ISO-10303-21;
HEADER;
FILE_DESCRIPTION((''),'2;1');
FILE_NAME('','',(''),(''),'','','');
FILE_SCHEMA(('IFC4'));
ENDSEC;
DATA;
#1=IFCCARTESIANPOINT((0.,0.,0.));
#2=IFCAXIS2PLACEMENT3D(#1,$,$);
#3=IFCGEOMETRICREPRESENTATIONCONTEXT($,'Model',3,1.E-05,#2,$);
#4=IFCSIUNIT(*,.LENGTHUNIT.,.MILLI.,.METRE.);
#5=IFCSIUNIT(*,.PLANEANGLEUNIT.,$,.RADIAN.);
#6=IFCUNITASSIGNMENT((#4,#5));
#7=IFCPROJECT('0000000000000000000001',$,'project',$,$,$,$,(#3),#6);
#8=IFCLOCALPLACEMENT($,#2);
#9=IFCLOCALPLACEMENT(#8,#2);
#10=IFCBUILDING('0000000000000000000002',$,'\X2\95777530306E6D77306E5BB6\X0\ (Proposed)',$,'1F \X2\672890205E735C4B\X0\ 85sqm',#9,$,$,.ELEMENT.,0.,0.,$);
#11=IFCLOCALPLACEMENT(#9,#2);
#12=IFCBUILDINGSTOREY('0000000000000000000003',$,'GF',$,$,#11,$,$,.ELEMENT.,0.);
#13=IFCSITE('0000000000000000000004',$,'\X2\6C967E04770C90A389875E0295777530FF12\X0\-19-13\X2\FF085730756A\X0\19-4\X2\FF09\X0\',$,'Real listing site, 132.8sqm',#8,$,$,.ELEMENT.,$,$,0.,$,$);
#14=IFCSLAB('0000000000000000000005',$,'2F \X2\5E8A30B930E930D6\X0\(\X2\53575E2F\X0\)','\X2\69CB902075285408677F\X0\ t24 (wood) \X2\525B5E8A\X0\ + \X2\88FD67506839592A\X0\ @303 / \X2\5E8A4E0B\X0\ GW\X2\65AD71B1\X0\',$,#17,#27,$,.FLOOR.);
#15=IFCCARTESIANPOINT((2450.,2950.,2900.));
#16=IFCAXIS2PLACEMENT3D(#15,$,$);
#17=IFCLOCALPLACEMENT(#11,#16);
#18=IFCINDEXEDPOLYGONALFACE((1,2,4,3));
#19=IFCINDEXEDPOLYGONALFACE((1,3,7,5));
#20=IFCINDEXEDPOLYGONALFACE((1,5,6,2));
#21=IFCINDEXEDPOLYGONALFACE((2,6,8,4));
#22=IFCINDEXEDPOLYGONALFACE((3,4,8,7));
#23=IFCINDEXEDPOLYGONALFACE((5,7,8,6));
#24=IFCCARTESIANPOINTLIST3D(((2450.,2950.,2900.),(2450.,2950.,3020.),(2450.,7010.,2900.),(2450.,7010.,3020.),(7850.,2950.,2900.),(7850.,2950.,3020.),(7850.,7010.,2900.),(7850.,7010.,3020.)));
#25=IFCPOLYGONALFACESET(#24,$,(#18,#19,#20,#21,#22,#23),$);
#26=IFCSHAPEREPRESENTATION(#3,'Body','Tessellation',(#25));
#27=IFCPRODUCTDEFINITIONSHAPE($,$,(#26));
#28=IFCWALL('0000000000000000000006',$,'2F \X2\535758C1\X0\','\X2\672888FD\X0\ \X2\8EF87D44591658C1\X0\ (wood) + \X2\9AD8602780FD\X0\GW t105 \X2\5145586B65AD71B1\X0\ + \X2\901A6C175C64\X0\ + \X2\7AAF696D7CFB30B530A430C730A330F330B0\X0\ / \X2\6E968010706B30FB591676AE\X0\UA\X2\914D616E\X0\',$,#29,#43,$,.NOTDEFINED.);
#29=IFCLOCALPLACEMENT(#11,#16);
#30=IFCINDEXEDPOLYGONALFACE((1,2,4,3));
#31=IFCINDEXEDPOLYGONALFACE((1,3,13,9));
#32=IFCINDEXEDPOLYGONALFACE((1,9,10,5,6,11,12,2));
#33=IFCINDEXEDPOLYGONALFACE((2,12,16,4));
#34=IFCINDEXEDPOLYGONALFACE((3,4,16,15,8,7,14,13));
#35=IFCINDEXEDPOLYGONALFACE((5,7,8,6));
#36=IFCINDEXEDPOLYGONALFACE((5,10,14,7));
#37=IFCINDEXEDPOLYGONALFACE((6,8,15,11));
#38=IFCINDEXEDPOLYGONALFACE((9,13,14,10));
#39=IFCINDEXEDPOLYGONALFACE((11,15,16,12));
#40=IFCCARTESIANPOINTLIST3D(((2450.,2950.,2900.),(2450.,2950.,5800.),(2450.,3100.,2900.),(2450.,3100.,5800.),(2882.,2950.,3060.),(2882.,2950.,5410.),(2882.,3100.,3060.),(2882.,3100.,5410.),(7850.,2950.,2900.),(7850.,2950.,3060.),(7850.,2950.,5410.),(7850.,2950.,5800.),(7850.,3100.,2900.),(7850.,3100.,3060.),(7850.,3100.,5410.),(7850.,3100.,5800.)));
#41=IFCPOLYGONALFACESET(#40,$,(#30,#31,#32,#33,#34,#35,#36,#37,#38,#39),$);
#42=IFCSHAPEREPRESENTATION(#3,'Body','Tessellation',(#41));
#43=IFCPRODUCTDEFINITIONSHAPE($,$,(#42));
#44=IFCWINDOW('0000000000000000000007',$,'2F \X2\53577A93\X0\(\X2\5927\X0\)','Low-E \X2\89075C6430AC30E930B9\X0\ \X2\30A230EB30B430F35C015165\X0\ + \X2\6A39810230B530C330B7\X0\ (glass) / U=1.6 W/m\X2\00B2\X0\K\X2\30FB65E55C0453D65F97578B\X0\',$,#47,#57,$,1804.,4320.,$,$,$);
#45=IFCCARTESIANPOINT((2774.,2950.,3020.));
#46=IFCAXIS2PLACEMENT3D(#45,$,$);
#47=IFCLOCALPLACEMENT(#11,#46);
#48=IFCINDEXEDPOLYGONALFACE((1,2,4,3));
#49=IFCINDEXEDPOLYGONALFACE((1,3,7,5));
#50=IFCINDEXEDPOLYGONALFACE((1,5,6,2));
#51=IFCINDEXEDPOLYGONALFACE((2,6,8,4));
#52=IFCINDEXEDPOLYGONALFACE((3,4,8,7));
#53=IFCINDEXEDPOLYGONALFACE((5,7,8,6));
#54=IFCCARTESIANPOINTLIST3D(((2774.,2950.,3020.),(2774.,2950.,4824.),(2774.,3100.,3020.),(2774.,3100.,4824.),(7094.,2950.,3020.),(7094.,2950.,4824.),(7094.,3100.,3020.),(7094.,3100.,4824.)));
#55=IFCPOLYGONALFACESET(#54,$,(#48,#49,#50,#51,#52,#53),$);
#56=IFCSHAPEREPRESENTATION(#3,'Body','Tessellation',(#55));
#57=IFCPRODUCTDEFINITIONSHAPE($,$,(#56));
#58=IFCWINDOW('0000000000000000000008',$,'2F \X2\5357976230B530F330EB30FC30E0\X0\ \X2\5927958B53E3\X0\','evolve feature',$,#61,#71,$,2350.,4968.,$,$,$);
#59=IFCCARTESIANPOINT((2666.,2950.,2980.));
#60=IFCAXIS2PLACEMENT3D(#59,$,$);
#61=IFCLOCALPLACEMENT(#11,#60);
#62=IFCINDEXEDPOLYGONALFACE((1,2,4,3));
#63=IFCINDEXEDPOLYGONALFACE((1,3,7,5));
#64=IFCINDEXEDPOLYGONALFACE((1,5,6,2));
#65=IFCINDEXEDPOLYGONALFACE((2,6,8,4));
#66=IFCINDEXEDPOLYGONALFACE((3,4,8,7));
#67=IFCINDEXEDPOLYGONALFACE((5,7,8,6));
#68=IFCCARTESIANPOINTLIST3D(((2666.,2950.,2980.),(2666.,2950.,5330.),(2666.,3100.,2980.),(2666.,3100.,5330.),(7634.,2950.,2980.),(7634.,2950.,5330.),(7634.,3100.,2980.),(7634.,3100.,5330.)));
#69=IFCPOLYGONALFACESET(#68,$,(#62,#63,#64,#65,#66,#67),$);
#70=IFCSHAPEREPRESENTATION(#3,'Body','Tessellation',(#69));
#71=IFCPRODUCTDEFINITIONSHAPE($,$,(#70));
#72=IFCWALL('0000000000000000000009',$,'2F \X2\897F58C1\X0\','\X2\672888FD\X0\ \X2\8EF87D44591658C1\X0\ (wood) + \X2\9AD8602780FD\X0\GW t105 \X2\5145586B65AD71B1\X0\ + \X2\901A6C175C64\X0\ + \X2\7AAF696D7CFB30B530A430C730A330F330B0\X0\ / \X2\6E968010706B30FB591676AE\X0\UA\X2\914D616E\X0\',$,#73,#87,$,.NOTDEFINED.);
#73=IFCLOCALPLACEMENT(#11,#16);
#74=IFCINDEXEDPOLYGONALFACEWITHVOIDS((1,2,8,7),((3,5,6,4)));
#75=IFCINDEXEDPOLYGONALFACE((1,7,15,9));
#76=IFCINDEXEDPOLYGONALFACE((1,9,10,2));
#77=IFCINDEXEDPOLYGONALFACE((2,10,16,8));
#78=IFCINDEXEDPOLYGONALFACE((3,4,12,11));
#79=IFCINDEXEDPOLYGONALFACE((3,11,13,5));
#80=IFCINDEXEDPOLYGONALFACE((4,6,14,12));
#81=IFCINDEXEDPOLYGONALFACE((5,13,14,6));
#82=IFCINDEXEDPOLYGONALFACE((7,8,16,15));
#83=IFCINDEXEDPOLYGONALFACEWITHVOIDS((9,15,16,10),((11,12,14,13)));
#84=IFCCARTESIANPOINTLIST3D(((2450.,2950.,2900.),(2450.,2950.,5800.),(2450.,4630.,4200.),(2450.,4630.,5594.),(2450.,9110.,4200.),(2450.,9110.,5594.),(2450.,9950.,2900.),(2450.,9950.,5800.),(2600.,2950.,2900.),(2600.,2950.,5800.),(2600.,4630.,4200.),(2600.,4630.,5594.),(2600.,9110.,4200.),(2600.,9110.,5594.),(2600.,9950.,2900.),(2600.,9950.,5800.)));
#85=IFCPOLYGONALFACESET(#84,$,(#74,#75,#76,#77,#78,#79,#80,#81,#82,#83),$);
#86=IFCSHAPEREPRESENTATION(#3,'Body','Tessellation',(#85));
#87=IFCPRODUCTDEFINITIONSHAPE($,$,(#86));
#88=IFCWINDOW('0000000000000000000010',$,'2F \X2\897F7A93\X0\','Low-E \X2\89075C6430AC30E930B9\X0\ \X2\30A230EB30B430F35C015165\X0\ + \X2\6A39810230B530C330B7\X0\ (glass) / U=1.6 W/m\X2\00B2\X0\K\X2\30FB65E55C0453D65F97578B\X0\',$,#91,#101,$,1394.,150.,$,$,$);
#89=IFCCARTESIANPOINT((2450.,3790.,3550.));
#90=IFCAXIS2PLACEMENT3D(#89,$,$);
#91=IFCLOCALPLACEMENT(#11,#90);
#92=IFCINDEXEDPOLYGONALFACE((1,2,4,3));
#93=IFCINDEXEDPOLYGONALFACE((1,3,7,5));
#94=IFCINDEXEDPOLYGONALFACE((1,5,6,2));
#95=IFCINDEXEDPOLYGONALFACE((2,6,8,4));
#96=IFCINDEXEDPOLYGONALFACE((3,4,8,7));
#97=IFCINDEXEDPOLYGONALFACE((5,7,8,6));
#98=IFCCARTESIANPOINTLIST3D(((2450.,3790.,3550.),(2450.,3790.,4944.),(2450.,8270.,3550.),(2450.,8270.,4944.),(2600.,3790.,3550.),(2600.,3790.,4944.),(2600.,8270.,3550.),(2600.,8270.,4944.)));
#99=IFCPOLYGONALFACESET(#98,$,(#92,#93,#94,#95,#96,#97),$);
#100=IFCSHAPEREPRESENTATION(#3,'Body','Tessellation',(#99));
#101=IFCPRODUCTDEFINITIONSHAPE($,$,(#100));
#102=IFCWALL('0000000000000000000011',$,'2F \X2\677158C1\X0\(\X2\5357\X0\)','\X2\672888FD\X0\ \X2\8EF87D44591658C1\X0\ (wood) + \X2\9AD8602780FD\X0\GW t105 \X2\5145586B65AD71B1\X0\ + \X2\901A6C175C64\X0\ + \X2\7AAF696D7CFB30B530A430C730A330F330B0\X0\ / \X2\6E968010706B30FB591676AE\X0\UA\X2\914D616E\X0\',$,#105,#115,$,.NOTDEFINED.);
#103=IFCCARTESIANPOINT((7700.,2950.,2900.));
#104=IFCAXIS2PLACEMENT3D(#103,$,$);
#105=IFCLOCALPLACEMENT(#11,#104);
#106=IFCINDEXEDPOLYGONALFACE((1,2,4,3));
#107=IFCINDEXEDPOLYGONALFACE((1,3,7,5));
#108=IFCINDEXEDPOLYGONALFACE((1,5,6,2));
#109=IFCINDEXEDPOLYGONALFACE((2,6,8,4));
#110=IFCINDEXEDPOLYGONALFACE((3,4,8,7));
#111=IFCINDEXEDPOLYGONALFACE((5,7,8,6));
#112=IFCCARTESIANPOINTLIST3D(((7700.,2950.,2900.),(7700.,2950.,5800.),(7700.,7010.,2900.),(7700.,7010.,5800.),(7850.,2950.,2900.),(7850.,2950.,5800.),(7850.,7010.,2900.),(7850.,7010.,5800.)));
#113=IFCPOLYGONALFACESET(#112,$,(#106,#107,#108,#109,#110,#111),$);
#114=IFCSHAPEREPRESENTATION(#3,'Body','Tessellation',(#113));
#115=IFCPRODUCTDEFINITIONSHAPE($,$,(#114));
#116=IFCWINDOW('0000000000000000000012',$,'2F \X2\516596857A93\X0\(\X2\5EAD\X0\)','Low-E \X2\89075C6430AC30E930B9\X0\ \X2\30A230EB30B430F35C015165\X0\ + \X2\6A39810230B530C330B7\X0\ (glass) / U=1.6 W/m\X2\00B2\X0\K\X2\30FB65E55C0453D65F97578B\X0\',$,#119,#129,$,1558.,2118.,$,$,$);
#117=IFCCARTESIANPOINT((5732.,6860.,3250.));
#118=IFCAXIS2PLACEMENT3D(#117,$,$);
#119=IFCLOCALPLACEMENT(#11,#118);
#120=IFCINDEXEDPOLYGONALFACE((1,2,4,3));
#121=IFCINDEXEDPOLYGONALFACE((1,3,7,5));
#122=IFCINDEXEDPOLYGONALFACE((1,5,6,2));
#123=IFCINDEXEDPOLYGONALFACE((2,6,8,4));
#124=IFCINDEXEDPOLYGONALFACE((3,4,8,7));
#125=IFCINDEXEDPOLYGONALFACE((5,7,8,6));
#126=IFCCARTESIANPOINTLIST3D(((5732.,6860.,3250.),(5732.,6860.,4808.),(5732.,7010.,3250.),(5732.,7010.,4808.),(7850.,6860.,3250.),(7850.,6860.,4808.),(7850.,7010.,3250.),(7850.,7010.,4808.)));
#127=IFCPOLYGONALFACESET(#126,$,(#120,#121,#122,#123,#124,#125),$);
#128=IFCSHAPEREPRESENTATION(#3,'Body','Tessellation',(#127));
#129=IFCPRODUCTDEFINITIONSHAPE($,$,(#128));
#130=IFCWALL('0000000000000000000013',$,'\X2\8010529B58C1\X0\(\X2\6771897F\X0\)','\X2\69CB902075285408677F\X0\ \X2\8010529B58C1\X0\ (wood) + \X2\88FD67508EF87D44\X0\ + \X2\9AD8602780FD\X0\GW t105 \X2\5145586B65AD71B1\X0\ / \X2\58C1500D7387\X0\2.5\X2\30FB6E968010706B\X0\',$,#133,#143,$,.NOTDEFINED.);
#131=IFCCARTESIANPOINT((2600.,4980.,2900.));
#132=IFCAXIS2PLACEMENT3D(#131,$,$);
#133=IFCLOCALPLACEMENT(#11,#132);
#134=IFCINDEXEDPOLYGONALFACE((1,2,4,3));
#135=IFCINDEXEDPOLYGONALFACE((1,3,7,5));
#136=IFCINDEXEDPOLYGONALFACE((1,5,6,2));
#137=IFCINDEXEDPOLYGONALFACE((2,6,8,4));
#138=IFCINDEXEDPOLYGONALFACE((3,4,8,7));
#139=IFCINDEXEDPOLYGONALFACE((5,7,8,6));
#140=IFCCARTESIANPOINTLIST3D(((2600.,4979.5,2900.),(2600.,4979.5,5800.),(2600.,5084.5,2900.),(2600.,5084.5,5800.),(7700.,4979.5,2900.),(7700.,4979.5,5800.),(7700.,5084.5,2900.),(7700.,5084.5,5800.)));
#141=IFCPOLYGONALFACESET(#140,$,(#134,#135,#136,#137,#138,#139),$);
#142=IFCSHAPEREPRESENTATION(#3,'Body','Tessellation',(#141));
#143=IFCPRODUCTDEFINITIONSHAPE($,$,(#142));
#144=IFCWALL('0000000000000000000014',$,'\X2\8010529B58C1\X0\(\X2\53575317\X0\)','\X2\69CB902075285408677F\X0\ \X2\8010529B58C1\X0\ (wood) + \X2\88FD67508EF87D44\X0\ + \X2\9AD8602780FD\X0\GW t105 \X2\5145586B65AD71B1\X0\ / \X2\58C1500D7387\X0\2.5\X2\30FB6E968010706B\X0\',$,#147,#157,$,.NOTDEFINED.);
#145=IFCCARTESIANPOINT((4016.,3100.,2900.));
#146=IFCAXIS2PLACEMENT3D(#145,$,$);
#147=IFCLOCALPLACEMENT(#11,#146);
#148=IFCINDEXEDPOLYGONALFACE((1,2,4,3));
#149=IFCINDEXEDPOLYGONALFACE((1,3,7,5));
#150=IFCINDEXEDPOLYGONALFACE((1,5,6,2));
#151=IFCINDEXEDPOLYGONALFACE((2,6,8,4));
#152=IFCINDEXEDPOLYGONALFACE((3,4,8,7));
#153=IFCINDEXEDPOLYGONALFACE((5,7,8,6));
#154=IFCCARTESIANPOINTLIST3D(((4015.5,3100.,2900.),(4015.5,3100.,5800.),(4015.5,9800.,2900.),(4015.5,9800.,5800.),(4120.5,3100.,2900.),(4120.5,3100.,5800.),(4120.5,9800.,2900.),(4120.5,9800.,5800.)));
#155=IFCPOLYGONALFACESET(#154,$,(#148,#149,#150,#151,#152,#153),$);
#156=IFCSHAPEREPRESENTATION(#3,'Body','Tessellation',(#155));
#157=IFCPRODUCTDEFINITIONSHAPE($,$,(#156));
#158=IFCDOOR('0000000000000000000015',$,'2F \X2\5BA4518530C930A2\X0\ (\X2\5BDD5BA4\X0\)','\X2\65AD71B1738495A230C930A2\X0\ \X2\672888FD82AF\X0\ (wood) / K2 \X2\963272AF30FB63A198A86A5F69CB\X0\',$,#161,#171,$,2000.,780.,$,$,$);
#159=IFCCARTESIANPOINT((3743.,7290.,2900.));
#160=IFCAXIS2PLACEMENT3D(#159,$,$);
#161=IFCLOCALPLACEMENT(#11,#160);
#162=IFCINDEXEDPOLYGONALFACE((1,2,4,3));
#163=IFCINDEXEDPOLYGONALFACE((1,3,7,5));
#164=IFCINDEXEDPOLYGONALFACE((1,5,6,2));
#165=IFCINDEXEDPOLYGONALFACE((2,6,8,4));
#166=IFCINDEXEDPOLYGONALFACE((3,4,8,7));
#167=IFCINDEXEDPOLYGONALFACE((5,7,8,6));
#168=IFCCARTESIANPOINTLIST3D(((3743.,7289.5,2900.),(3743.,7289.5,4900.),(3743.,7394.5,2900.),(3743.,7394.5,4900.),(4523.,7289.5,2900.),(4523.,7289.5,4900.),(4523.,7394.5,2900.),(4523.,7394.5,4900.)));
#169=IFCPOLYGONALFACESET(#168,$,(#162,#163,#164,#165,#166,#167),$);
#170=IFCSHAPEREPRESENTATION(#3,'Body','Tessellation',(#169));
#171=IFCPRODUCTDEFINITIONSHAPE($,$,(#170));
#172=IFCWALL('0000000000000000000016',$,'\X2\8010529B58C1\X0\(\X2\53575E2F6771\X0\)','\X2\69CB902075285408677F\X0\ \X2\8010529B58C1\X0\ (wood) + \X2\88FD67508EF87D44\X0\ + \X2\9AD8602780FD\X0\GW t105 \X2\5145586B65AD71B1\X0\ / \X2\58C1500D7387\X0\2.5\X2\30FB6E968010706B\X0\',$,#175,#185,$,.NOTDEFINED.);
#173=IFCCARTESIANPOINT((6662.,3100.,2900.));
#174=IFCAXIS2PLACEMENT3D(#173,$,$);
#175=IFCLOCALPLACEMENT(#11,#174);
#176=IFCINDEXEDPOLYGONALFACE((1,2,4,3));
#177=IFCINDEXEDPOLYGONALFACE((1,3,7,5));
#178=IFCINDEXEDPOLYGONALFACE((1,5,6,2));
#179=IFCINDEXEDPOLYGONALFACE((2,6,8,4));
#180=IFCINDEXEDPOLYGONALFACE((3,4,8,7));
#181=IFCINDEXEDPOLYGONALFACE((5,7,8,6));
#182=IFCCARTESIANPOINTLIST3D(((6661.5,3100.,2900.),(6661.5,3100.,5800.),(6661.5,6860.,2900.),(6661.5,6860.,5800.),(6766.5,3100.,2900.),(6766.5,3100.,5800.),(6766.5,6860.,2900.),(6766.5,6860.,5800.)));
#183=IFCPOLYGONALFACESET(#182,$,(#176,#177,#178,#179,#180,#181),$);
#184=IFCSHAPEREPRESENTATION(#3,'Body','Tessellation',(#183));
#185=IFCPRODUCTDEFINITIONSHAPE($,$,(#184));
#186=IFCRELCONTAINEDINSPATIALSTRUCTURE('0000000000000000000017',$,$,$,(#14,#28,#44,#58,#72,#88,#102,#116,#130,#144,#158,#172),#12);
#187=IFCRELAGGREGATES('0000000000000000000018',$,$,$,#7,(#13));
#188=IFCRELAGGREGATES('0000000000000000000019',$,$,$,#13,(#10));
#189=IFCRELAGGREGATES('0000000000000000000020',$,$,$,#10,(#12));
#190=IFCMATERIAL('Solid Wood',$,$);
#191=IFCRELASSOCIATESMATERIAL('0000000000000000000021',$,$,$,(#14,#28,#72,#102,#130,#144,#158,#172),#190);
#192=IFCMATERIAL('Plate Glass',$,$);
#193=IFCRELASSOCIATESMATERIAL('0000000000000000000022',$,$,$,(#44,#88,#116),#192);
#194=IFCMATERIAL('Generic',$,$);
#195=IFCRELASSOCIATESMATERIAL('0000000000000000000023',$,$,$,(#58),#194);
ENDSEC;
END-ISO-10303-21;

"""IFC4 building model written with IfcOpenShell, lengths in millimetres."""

from ifc_helpers import new_model, si_unit, frame, frame_2d, origin, place, context, project, spatial, rectangle, extrude, material, element, fill, save


model = new_model("IFC4")

# Units and contexts
model_context = context("Model", 3, precision=1e-05, world=origin())
ifc_project = project(units=[si_unit("LENGTHUNIT", "METRE", prefix="MILLI"), si_unit("PLANEANGLEUNIT", "RADIAN")], contexts=[model_context])

# Site, building, storey
site_placement = place(None, origin())
site = spatial("IfcSite", under=ifc_project, at=site_placement, Name="沖縄県那覇市長田２-19-13（地番19-4）", ObjectType="Real listing site, 132.8sqm", CompositionType="ELEMENT", RefElevation=0.0)
building_placement = place(site_placement, origin())
building = spatial("IfcBuilding", under=site, at=building_placement, Name="長田の海の家 (Proposed)", ObjectType="1F 木造平屋 85sqm", CompositionType="ELEMENT", ElevationOfRefHeight=0.0, ElevationOfTerrain=0.0)
storey_placement = place(building_placement, origin())
storey = spatial("IfcBuildingStorey", under=building, at=storey_placement, Name="GF", CompositionType="ELEMENT", Elevation=0.0)

# Slab
ifc_material_1 = material(Name="Solid Wood")
slab_placement = place(storey_placement, frame((2450.0, 2950.0, 2900.0)))
element("IfcSlab", 1, at=slab_placement, inside=storey, material=ifc_material_1, Name="2F 床スラブ(南帯)", Description="構造用合板 t24 (wood) 剛床 + 製材根太 @303 / 床下 GW断熱", PredefinedType="FLOOR", context=model_context, shape_type="SweptSolid", body=[
    extrude(rectangle(XDim=5400.0, YDim=4060.0, at=frame_2d((2700.0, 2030.0))), frame((2450.0, 2950.0, 2900.0)), (0.0, 0.0, 1.0), 120.0),
])

# Wall, openings, windows
wall_1_placement = place(storey_placement, frame((2450.0, 2950.0, 2900.0)))
wall_1 = element("IfcWall", 2, at=wall_1_placement, inside=storey, material=ifc_material_1, Name="2F 南壁", Description="木製 軸組外壁 (wood) + 高性能GW t105 充填断熱 + 通気層 + 窯業系サイディング / 準耐火・外皮UA配慮", PredefinedType="NOTDEFINED", context=model_context, shape_type="SweptSolid", body=[
    extrude(rectangle(XDim=5400.0, YDim=150.0, at=frame_2d((2700.0, 75.0))), frame((2450.0, 2950.0, 2900.0)), (0.0, 0.0, 1.0), 2900.0),
])
opening_1_placement = place(storey_placement, frame((2774.0, 2950.0, 3020.0)))
opening_1 = element("IfcOpeningElement", 3, at=opening_1_placement, cuts=wall_1, PredefinedType="NOTDEFINED", context=model_context, shape_type="SweptSolid", body=[
    extrude(rectangle(XDim=4320.0, YDim=150.0, at=frame_2d((2160.0, 75.0))), frame((2774.0, 2950.0, 3020.0)), (0.0, 0.0, 1.0), 1804.0),
])
opening_2_placement = place(storey_placement, frame((2666.0, 2950.0, 2980.0)))
opening_2 = element("IfcOpeningElement", 4, at=opening_2_placement, cuts=wall_1, PredefinedType="NOTDEFINED", context=model_context, shape_type="SweptSolid", body=[
    extrude(rectangle(XDim=4968.0, YDim=150.0, at=frame_2d((2484.0, 75.0))), frame((2666.0, 2950.0, 2980.0)), (0.0, 0.0, 1.0), 2350.0),
])
ifc_material_2 = material(Name="Plate Glass")
window_1_placement = place(storey_placement, frame((2774.0, 2950.0, 3020.0)))
window_1 = element("IfcWindow", 5, at=window_1_placement, inside=storey, material=ifc_material_2, Name="2F 南窓(大)", Description="Low-E 複層ガラス アルゴン封入 + 樹脂サッシ (glass) / U=1.6 W/m²K・日射取得型", OverallHeight=1804.0, OverallWidth=4320.0, context=model_context, shape_type="SweptSolid", body=[
    extrude(rectangle(XDim=4320.0, YDim=150.0, at=frame_2d((2160.0, 75.0))), frame((2774.0, 2950.0, 3020.0)), (0.0, 0.0, 1.0), 1804.0),
])
fill(opening_1, window_1)
ifc_material_3 = material(Name="Generic")
window_2_placement = place(storey_placement, frame((2666.0, 2950.0, 2980.0)))
window_2 = element("IfcWindow", 6, at=window_2_placement, inside=storey, material=ifc_material_3, Name="2F 南面サンルーム 大開口", Description="evolve feature", OverallHeight=2350.0, OverallWidth=4968.0, context=model_context, shape_type="SweptSolid", body=[
    extrude(rectangle(XDim=4968.0, YDim=150.0, at=frame_2d((2484.0, 75.0))), frame((2666.0, 2950.0, 2980.0)), (0.0, 0.0, 1.0), 2350.0),
])
fill(opening_2, window_2)

# Walls, openings, windows
wall_2_placement = place(storey_placement, frame((2450.0, 2950.0, 2900.0)))
wall_2 = element("IfcWall", 7, at=wall_2_placement, inside=storey, material=ifc_material_1, Name="2F 西壁", Description="木製 軸組外壁 (wood) + 高性能GW t105 充填断熱 + 通気層 + 窯業系サイディング / 準耐火・外皮UA配慮", PredefinedType="NOTDEFINED", context=model_context, shape_type="SweptSolid", body=[
    extrude(rectangle(XDim=150.0, YDim=7000.0, at=frame_2d((75.0, 3500.0))), frame((2450.0, 2950.0, 2900.0)), (0.0, 0.0, 1.0), 2900.0),
])
opening_3_placement = place(storey_placement, frame((2450.0, 3790.0, 3550.0)))
opening_3 = element("IfcOpeningElement", 8, at=opening_3_placement, cuts=wall_2, PredefinedType="NOTDEFINED", context=model_context, shape_type="SweptSolid", body=[
    extrude(rectangle(XDim=150.0, YDim=4480.0, at=frame_2d((75.0, 2240.0))), frame((2450.0, 3790.0, 3550.0)), (0.0, 0.0, 1.0), 1394.0),
])
window_3_placement = place(storey_placement, frame((2450.0, 3790.0, 3550.0)))
window_3 = element("IfcWindow", 9, at=window_3_placement, inside=storey, material=ifc_material_2, Name="2F 西窓", Description="Low-E 複層ガラス アルゴン封入 + 樹脂サッシ (glass) / U=1.6 W/m²K・日射取得型", OverallHeight=1394.0, OverallWidth=150.0, context=model_context, shape_type="SweptSolid", body=[
    extrude(rectangle(XDim=150.0, YDim=4480.0, at=frame_2d((75.0, 2240.0))), frame((2450.0, 3790.0, 3550.0)), (0.0, 0.0, 1.0), 1394.0),
])
fill(opening_3, window_3)
wall_3_placement = place(storey_placement, frame((7700.0, 2950.0, 2900.0)))
wall_3 = element("IfcWall", 10, at=wall_3_placement, inside=storey, material=ifc_material_1, Name="2F 東壁(南)", Description="木製 軸組外壁 (wood) + 高性能GW t105 充填断熱 + 通気層 + 窯業系サイディング / 準耐火・外皮UA配慮", PredefinedType="NOTDEFINED", context=model_context, shape_type="SweptSolid", body=[
    extrude(rectangle(XDim=150.0, YDim=4060.0, at=frame_2d((75.0, 2030.0))), frame((7700.0, 2950.0, 2900.0)), (0.0, 0.0, 1.0), 2900.0),
])
opening_4_placement = place(storey_placement, frame((5732.0, 6860.0, 3250.0)))
opening_4 = element("IfcOpeningElement", 11, at=opening_4_placement, cuts=wall_3, PredefinedType="NOTDEFINED", context=model_context, shape_type="SweptSolid", body=[
    extrude(rectangle(XDim=2118.0, YDim=150.0, at=frame_2d((1059.0, 75.0))), frame((5732.0, 6860.0, 3250.0)), (0.0, 0.0, 1.0), 1558.0),
])
window_4_placement = place(storey_placement, frame((5732.0, 6860.0, 3250.0)))
window_4 = element("IfcWindow", 12, at=window_4_placement, inside=storey, material=ifc_material_2, Name="2F 入隅窓(庭)", Description="Low-E 複層ガラス アルゴン封入 + 樹脂サッシ (glass) / U=1.6 W/m²K・日射取得型", OverallHeight=1558.0, OverallWidth=2118.0, context=model_context, shape_type="SweptSolid", body=[
    extrude(rectangle(XDim=2118.0, YDim=150.0, at=frame_2d((1059.0, 75.0))), frame((5732.0, 6860.0, 3250.0)), (0.0, 0.0, 1.0), 1558.0),
])
fill(opening_4, window_4)

# Wall
wall_4_placement = place(storey_placement, frame((2600.0, 4980.0, 2900.0)))
element("IfcWall", 13, at=wall_4_placement, inside=storey, material=ifc_material_1, Name="耐力壁(東西)", Description="構造用合板 耐力壁 (wood) + 製材軸組 + 高性能GW t105 充填断熱 / 壁倍率2.5・準耐火", PredefinedType="NOTDEFINED", context=model_context, shape_type="SweptSolid", body=[
    extrude(rectangle(XDim=5100.0, YDim=105.0, at=frame_2d((2550.0, 52.0))), frame((2600.0, 4980.0, 2900.0)), (0.0, 0.0, 1.0), 2900.0),
])

# Wall, opening, door
wall_5_placement = place(storey_placement, frame((4016.0, 3100.0, 2900.0)))
wall_5 = element("IfcWall", 14, at=wall_5_placement, inside=storey, material=ifc_material_1, Name="耐力壁(南北)", Description="構造用合板 耐力壁 (wood) + 製材軸組 + 高性能GW t105 充填断熱 / 壁倍率2.5・準耐火", PredefinedType="NOTDEFINED", context=model_context, shape_type="SweptSolid", body=[
    extrude(rectangle(XDim=105.0, YDim=6700.0, at=frame_2d((52.0, 3350.0))), frame((4016.0, 3100.0, 2900.0)), (0.0, 0.0, 1.0), 2900.0),
])
opening_5_placement = place(storey_placement, frame((3743.0, 7290.0, 2900.0)))
opening_5 = element("IfcOpeningElement", 15, at=opening_5_placement, cuts=wall_5, PredefinedType="NOTDEFINED", context=model_context, shape_type="SweptSolid", body=[
    extrude(rectangle(XDim=780.0, YDim=105.0, at=frame_2d((390.0, 52.0))), frame((3743.0, 7290.0, 2900.0)), (0.0, 0.0, 1.0), 2000.0),
])
door_placement = place(storey_placement, frame((3743.0, 7290.0, 2900.0)))
door = element("IfcDoor", 16, at=door_placement, inside=storey, material=ifc_material_1, Name="2F 室内ドア (寝室)", Description="断熱玄関ドア 木製芯 (wood) / K2 防犯・採風機構", OverallHeight=2000.0, OverallWidth=780.0, context=model_context, shape_type="SweptSolid", body=[
    extrude(rectangle(XDim=780.0, YDim=105.0, at=frame_2d((390.0, 52.0))), frame((3743.0, 7290.0, 2900.0)), (0.0, 0.0, 1.0), 2000.0),
])
fill(opening_5, door)

# Wall
wall_6_placement = place(storey_placement, frame((6662.0, 3100.0, 2900.0)))
element("IfcWall", 17, at=wall_6_placement, inside=storey, material=ifc_material_1, Name="耐力壁(南帯東)", Description="構造用合板 耐力壁 (wood) + 製材軸組 + 高性能GW t105 充填断熱 / 壁倍率2.5・準耐火", PredefinedType="NOTDEFINED", context=model_context, shape_type="SweptSolid", body=[
    extrude(rectangle(XDim=105.0, YDim=3760.0, at=frame_2d((52.0, 1880.0))), frame((6662.0, 3100.0, 2900.0)), (0.0, 0.0, 1.0), 2900.0),
])

save(model, "model.ifc")
